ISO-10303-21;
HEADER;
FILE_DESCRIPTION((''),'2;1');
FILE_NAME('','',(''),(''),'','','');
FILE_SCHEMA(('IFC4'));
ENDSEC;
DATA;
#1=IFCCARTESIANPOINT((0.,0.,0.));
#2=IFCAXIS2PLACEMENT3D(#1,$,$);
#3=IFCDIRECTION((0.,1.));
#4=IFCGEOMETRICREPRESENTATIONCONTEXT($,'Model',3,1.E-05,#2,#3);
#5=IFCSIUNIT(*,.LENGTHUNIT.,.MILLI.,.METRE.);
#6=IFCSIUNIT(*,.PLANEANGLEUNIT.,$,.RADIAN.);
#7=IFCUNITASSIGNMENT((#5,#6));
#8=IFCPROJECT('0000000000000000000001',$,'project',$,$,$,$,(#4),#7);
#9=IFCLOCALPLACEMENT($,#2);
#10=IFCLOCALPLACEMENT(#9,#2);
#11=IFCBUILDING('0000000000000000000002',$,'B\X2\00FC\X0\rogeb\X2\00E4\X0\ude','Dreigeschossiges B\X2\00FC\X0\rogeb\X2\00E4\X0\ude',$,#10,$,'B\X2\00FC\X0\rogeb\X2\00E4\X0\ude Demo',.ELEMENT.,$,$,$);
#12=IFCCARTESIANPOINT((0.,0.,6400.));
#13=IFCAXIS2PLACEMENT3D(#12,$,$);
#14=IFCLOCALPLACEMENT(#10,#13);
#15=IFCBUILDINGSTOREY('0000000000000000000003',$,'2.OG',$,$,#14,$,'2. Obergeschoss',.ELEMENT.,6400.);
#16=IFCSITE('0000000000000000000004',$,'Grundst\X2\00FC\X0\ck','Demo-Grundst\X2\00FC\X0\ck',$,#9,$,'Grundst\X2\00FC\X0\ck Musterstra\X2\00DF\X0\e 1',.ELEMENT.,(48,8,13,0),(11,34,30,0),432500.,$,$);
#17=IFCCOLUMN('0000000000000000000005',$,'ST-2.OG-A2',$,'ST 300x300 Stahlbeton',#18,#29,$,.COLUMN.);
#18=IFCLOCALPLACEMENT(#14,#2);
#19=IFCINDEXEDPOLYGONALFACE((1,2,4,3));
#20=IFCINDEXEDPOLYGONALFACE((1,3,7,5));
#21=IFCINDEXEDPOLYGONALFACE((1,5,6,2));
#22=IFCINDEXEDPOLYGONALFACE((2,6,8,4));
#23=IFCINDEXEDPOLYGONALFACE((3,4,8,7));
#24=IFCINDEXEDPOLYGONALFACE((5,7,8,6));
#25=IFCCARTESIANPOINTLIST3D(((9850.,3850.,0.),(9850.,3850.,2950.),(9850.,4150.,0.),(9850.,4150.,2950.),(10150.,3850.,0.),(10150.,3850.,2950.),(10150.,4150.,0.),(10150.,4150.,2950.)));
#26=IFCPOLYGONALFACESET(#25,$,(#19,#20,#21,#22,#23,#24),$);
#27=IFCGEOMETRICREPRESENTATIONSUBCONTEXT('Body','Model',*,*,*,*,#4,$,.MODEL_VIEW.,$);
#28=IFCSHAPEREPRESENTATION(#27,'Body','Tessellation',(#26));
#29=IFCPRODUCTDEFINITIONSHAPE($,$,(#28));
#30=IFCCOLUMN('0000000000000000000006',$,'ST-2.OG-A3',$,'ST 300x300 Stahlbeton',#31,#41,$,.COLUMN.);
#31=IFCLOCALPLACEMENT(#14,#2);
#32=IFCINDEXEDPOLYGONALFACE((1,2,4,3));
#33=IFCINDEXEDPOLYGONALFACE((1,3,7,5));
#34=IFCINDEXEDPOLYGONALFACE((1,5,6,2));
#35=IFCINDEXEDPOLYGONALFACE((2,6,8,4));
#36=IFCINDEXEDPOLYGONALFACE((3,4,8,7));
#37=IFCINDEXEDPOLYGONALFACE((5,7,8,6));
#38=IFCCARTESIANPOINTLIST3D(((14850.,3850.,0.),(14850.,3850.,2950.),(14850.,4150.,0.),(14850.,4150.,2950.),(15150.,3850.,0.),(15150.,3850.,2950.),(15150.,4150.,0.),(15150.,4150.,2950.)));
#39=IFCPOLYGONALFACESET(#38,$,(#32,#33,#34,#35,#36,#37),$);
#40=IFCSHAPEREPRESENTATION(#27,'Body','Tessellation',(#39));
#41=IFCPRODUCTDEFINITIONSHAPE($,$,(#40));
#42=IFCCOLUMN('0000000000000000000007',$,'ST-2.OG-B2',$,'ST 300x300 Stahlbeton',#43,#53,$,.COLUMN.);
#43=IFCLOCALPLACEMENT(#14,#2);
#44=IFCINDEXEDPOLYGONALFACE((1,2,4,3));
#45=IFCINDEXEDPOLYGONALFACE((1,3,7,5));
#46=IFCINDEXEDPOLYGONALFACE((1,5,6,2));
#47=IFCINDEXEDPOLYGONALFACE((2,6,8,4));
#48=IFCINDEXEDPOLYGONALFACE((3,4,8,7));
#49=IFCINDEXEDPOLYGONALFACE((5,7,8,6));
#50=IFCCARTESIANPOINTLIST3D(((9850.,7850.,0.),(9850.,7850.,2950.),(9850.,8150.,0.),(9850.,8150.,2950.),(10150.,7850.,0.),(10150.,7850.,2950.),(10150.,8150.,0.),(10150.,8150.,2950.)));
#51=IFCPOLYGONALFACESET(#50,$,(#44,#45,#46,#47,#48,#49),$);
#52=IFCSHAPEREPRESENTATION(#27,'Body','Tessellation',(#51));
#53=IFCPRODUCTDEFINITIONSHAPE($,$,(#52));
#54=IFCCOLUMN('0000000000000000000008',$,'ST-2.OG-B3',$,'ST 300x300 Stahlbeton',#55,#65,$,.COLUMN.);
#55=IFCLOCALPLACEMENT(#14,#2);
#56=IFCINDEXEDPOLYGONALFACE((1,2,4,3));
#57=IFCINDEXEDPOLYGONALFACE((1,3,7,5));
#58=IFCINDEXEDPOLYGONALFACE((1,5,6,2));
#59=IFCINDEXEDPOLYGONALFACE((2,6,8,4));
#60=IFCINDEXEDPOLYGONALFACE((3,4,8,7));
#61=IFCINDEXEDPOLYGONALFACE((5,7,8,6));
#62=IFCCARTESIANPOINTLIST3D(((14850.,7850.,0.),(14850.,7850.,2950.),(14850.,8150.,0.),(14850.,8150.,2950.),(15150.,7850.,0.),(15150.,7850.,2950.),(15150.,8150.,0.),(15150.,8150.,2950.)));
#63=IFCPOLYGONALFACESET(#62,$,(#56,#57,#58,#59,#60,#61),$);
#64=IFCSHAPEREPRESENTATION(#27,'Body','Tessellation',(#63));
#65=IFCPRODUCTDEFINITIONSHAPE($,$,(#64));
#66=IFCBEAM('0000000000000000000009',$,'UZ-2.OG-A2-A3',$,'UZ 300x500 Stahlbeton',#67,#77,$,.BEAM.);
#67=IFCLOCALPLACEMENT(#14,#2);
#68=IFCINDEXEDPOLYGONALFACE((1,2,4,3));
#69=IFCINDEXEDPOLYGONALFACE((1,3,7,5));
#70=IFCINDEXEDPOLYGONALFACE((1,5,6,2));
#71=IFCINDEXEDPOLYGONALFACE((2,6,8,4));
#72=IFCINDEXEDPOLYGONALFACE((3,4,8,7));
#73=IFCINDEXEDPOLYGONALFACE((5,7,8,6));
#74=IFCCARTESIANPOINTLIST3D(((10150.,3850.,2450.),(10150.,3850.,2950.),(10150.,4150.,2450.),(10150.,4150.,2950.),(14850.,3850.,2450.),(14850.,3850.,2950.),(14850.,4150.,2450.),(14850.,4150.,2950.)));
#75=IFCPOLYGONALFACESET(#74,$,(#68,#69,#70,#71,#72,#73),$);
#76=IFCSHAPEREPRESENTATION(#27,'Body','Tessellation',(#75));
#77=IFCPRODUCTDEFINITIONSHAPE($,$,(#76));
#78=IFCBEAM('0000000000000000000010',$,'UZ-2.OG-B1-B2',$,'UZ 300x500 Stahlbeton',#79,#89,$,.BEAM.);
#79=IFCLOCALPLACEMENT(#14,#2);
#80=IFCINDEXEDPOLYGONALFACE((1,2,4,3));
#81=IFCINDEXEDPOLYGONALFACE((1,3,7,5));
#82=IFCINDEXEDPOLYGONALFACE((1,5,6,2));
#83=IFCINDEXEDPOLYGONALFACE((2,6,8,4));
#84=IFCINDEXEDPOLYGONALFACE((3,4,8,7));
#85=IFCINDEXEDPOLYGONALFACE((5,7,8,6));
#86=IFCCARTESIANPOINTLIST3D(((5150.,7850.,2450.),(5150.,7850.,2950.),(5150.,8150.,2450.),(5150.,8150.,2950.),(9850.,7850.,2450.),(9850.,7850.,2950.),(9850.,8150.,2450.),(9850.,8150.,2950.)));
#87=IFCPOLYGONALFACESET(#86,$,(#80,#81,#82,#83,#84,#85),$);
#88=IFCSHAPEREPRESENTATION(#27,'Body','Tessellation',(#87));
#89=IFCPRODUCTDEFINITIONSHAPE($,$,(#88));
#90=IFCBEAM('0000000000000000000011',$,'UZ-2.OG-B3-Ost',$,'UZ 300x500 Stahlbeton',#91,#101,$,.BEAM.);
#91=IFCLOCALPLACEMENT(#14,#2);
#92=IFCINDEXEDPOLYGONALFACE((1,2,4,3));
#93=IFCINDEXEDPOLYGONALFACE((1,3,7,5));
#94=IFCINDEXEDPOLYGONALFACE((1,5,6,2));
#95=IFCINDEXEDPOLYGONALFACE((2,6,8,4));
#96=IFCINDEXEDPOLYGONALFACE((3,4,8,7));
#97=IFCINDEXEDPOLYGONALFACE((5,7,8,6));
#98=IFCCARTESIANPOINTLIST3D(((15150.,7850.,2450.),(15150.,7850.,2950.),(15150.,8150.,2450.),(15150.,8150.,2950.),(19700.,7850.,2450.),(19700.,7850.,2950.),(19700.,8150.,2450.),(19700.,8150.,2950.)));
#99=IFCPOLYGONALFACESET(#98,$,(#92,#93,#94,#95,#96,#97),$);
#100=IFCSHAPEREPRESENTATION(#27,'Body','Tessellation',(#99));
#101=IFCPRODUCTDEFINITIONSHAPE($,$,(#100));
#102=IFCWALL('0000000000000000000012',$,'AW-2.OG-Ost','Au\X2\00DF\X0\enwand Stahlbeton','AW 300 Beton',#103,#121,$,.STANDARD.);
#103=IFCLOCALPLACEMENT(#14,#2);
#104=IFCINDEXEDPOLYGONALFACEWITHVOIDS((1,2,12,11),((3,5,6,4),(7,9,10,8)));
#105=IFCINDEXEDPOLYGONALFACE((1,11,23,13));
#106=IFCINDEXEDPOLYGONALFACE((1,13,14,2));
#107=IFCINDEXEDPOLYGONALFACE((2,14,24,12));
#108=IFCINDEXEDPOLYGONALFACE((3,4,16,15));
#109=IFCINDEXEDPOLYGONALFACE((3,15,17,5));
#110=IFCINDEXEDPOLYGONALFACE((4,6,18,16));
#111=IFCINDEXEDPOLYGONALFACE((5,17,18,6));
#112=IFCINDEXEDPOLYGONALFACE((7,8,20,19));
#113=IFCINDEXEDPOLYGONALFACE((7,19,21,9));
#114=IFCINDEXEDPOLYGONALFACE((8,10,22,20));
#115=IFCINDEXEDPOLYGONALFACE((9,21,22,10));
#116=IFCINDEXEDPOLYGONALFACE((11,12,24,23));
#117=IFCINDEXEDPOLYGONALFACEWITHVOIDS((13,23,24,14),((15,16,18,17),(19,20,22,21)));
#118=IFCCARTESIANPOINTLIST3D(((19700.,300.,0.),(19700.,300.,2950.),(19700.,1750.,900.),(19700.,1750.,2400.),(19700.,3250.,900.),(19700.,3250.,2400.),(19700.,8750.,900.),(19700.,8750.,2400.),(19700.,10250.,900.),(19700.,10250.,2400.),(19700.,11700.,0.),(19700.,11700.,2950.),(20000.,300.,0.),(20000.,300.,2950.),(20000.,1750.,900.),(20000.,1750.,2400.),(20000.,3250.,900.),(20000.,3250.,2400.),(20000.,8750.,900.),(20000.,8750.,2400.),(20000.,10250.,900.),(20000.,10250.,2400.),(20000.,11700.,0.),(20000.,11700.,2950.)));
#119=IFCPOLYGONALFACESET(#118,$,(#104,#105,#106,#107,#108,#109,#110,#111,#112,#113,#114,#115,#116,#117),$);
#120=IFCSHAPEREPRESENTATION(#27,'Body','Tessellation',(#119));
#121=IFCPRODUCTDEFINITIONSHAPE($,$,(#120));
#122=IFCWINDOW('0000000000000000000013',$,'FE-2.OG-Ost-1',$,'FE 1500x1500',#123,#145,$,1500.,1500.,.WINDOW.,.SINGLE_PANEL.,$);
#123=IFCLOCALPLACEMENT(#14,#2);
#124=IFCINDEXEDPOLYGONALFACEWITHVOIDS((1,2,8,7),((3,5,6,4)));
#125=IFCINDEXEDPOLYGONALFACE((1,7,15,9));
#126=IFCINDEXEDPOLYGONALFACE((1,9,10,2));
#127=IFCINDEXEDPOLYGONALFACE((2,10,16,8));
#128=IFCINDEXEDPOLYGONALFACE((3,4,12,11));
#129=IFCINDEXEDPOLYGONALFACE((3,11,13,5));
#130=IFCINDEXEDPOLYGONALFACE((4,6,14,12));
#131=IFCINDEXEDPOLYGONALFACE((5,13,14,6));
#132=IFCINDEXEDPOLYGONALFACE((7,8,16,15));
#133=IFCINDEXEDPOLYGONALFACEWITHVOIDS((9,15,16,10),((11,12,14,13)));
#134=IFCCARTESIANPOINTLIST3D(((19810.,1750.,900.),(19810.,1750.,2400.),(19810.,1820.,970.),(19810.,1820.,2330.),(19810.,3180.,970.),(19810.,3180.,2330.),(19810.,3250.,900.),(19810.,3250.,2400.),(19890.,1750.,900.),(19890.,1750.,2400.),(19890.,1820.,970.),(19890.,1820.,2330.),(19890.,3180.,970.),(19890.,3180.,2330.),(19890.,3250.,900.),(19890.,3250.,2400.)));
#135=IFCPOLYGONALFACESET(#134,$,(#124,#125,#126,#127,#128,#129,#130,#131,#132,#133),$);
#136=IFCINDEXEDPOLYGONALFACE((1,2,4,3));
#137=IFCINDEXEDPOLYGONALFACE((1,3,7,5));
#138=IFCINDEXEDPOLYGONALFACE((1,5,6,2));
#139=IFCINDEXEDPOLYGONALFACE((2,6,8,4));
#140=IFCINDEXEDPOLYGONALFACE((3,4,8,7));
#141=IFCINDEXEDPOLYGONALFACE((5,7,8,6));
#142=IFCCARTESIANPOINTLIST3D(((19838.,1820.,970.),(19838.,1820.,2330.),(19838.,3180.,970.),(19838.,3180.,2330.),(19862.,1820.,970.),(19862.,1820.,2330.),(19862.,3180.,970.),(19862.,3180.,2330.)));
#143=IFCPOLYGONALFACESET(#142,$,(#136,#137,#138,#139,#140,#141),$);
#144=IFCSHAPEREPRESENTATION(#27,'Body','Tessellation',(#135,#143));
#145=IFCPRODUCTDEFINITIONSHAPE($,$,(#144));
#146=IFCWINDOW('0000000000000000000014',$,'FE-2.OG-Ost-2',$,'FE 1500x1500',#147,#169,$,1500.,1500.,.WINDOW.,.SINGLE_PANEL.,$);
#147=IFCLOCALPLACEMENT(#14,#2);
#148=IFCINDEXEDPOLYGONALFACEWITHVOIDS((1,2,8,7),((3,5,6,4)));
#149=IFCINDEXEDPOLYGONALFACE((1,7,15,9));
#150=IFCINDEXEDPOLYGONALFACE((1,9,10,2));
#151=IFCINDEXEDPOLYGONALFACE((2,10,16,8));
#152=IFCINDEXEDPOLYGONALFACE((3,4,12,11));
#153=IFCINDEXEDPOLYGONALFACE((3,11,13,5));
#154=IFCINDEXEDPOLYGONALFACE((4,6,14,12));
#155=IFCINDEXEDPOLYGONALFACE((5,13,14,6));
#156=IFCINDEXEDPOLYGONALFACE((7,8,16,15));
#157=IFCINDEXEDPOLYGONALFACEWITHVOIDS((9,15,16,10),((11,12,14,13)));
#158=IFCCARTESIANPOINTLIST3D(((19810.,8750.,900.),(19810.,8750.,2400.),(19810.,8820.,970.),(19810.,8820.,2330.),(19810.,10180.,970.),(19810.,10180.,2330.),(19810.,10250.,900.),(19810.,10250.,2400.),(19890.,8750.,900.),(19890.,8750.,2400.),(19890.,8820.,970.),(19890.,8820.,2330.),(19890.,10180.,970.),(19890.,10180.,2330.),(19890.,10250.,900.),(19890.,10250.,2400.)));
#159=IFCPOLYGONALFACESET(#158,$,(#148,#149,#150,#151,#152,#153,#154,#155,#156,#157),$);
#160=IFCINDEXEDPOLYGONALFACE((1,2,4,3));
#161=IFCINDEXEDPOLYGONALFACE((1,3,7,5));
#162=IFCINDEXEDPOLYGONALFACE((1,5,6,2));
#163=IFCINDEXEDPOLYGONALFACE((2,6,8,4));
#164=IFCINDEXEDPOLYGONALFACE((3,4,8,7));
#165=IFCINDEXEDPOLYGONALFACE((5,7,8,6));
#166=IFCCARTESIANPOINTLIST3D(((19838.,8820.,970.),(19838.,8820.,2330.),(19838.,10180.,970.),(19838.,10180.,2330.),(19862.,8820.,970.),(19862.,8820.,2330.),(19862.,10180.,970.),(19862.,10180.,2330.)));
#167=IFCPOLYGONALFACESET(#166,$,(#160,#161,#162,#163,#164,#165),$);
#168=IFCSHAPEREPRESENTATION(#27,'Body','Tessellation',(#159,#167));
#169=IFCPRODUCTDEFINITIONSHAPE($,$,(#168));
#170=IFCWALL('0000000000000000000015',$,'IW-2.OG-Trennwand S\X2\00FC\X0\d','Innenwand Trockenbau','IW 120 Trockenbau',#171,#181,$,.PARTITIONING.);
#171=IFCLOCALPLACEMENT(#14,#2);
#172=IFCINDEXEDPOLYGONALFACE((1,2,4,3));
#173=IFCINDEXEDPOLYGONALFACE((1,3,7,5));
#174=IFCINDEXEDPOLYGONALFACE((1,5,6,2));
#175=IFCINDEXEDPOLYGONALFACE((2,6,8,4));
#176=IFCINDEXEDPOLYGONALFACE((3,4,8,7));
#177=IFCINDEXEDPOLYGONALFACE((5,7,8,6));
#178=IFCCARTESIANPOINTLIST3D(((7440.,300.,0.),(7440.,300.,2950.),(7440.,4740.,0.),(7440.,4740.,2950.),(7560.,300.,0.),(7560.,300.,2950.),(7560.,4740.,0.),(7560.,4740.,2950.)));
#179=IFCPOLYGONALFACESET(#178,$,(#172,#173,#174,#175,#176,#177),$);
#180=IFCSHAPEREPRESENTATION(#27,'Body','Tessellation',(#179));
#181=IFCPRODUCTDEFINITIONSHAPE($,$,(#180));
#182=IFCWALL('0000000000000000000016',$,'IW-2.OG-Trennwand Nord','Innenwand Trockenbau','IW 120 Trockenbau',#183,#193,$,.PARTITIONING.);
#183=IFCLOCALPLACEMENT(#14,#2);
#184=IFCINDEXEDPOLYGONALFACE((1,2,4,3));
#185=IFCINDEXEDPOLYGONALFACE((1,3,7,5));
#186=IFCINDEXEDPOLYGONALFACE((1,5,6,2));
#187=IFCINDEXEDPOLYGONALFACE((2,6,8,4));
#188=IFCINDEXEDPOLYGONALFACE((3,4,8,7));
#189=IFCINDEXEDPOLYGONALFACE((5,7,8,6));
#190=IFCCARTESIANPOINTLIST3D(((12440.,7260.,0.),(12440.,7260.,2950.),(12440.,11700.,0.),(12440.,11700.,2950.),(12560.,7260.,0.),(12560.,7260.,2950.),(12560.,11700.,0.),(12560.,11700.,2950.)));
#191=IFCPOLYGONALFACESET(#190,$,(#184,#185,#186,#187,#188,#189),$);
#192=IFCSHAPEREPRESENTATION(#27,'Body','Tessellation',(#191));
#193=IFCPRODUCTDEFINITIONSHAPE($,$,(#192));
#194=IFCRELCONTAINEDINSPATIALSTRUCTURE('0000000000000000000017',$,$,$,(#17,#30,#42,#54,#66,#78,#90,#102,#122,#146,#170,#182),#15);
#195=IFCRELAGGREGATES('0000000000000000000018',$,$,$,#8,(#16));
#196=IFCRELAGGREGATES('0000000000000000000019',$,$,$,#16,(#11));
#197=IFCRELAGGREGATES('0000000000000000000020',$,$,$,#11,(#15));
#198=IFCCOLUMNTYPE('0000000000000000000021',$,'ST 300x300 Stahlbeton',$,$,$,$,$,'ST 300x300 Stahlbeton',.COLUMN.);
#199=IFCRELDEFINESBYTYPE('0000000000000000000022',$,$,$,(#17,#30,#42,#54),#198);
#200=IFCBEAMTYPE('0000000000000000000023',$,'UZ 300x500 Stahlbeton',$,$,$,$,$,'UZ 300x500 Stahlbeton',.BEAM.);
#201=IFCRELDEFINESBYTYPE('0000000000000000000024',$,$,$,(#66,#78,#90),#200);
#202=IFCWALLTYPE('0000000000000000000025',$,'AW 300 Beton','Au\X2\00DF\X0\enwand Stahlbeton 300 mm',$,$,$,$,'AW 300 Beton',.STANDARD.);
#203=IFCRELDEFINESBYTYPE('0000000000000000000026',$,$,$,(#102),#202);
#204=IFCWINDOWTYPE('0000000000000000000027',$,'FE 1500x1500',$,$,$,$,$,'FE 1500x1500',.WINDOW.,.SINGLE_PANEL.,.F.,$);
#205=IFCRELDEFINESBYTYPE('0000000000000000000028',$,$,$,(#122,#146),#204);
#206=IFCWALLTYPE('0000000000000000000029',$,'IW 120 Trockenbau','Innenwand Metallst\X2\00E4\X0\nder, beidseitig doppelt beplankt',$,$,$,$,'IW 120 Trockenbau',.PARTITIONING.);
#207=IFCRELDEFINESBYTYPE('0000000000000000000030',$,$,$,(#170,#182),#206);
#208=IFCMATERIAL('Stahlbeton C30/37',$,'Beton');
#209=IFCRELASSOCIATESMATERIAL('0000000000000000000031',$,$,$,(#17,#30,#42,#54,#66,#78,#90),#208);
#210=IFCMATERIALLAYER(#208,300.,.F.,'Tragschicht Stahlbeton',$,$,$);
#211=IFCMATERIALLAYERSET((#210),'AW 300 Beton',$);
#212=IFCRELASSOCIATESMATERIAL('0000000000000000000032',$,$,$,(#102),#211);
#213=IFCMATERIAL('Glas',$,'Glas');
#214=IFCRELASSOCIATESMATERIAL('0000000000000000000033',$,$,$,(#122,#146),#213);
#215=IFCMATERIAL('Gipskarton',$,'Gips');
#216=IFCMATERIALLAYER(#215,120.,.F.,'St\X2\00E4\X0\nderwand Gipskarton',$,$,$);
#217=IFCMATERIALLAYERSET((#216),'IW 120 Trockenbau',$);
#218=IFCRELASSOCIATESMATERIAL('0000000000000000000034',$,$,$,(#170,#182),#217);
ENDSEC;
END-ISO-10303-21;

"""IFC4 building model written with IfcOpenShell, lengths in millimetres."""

from ifc_helpers import new_model, si_unit, direction, frame, frame_2d, origin, origin_2d, place, context, subcontext, project, spatial, polyline, rectangle, outline, extrude, material, layer, layer_set, layer_usage, type_object, element, fill, save


model = new_model("IFC4")

# Units and contexts
model_context = context("Model", 3, precision=1e-05, world=origin(), true_north=direction((0.0, 1.0)))
body_context = subcontext(model_context, "Body", "Model", "MODEL_VIEW")
ifc_project = project(units=[si_unit("LENGTHUNIT", "METRE", prefix="MILLI"), si_unit("PLANEANGLEUNIT", "RADIAN")], contexts=[model_context])

# Site, building, storey
site_placement = place(None, origin())
site = spatial("IfcSite", under=ifc_project, at=site_placement, Name="Grundstück", Description="Demo-Grundstück", LongName="Grundstück Musterstraße 1", CompositionType="ELEMENT", RefLatitude=(48, 8, 13, 0), RefLongitude=(11, 34, 30, 0), RefElevation=432500.0)
building_placement = place(site_placement, origin())
building = spatial("IfcBuilding", under=site, at=building_placement, Name="Bürogebäude", Description="Dreigeschossiges Bürogebäude", LongName="Bürogebäude Demo", CompositionType="ELEMENT")
storey_placement = place(building_placement, frame((0.0, 0.0, 6400.0)))
storey = spatial("IfcBuildingStorey", under=building, at=storey_placement, Name="2.OG", LongName="2. Obergeschoss", CompositionType="ELEMENT", Elevation=6400.0)

# Columns
ifc_material_1 = material(Name="Stahlbeton C30/37", Category="Beton")
column_type = type_object("IfcColumnType", Name="ST 300x300 Stahlbeton", ElementType="ST 300x300 Stahlbeton", PredefinedType="COLUMN")
for number, where, name in (
    (1, (10000.0, 4000.0, 0.0), "ST-2.OG-A2"),
    (2, (15000.0, 4000.0, 0.0), "ST-2.OG-A3"),
    (3, (10000.0, 8000.0, 0.0), "ST-2.OG-B2"),
    (4, (15000.0, 8000.0, 0.0), "ST-2.OG-B3"),
):
    element("IfcColumn", number, at=place(storey_placement, frame(where)), inside=storey, type_object=column_type, material=ifc_material_1, Name=name, ObjectType="ST 300x300 Stahlbeton", PredefinedType="COLUMN", context=body_context, shape_type="SweptSolid", body=[
        extrude(rectangle(XDim=300.0, YDim=300.0, at=origin_2d()), origin(), (0.0, 0.0, 1.0), 2950.0),
    ])

# Beams
beam_type = type_object("IfcBeamType", Name="UZ 300x500 Stahlbeton", ElementType="UZ 300x500 Stahlbeton", PredefinedType="BEAM")
for number, where, name in (
    (5, (10150.0, 4000.0, 2700.0), "UZ-2.OG-A2-A3"),
    (6, (5150.0, 8000.0, 2700.0), "UZ-2.OG-B1-B2"),
):
    element("IfcBeam", number, at=place(storey_placement, frame(where)), inside=storey, type_object=beam_type, material=ifc_material_1, Name=name, ObjectType="UZ 300x500 Stahlbeton", PredefinedType="BEAM", context=body_context, shape_type="SweptSolid", body=[
        extrude(rectangle(XDim=300.0, YDim=500.0, at=origin_2d()), frame((0.0, 0.0, 0.0), z_axis=(1.0, 0.0, 0.0), x_axis=(0.0, 1.0, 0.0)), (0.0, 0.0, 1.0), 4700.0),
    ])
beam_placement = place(storey_placement, frame((15150.0, 8000.0, 2700.0)))
element("IfcBeam", 7, at=beam_placement, inside=storey, type_object=beam_type, material=ifc_material_1, Name="UZ-2.OG-B3-Ost", ObjectType="UZ 300x500 Stahlbeton", PredefinedType="BEAM", context=body_context, shape_type="SweptSolid", body=[
    extrude(rectangle(XDim=300.0, YDim=500.0, at=origin_2d()), frame((0.0, 0.0, 0.0), z_axis=(1.0, 0.0, 0.0), x_axis=(0.0, 1.0, 0.0)), (0.0, 0.0, 1.0), 4550.0),
])

# Wall, openings, windows
ifc_layer_1 = layer(ifc_material_1, 300.0, ventilated=False, Name="Tragschicht Stahlbeton")
ifc_layer_set_1 = layer_set([ifc_layer_1], Name="AW 300 Beton")
ifc_layer_usage_1 = layer_usage(ifc_layer_set_1, "AXIS2", "POSITIVE", -150.0)
wall_type_1 = type_object("IfcWallType", Name="AW 300 Beton", Description="Außenwand Stahlbeton 300 mm", ElementType="AW 300 Beton", PredefinedType="STANDARD")
wall_placement = place(storey_placement, frame((19850.0, 300.0, 0.0), z_axis=(0.0, 0.0, 1.0), x_axis=(0.0, 1.0, 0.0)))
wall = element("IfcWall", 8, at=wall_placement, inside=storey, type_object=wall_type_1, material=ifc_layer_usage_1, Name="AW-2.OG-Ost", Description="Außenwand Stahlbeton", ObjectType="AW 300 Beton", PredefinedType="STANDARD", context=body_context, shape_type="SweptSolid", body=[
    extrude(rectangle(XDim=11400.0, YDim=300.0, at=frame_2d((5700.0, 0.0))), origin(), (0.0, 0.0, 1.0), 2950.0),
])
opening_1_placement = place(wall_placement, frame((2200.0, 0.0, 900.0)))
opening_1 = element("IfcOpeningElement", 9, at=opening_1_placement, cuts=wall, PredefinedType="OPENING", context=body_context, shape_type="SweptSolid", body=[
    extrude(rectangle(XDim=1500.0, YDim=340.0, at=origin_2d()), origin(), (0.0, 0.0, 1.0), 1500.0),
])
opening_2_placement = place(wall_placement, frame((9200.0, 0.0, 900.0)))
opening_2 = element("IfcOpeningElement", 10, at=opening_2_placement, cuts=wall, PredefinedType="OPENING", context=body_context, shape_type="SweptSolid", body=[
    extrude(rectangle(XDim=1500.0, YDim=340.0, at=origin_2d()), origin(), (0.0, 0.0, 1.0), 1500.0),
])
ifc_material_2 = material(Name="Glas", Category="Glas")
window_type = type_object("IfcWindowType", Name="FE 1500x1500", ElementType="FE 1500x1500", ParameterTakesPrecedence=False, PartitioningType="SINGLE_PANEL", PredefinedType="WINDOW")
window_1_placement = place(opening_1_placement, origin())
window_1 = element("IfcWindow", 11, at=window_1_placement, inside=storey, type_object=window_type, material=ifc_material_2, Name="FE-2.OG-Ost-1", ObjectType="FE 1500x1500", OverallHeight=1500.0, OverallWidth=1500.0, PartitioningType="SINGLE_PANEL", PredefinedType="WINDOW", context=body_context, shape_type="SweptSolid", body=[
    extrude(outline(polyline([(-750.0, 0.0), (750.0, 0.0), (750.0, 1500.0), (-750.0, 1500.0), (-750.0, 0.0)]), holes=[polyline([(-680.0, 70.0), (680.0, 70.0), (680.0, 1430.0), (-680.0, 1430.0), (-680.0, 70.0)])]), frame((0.0, 40.0, 0.0), z_axis=(0.0, -1.0, 0.0), x_axis=(1.0, 0.0, 0.0)), (0.0, 0.0, 1.0), 80.0),
    extrude(rectangle(XDim=1360.0, YDim=24.0, at=origin_2d()), frame((0.0, 0.0, 70.0)), (0.0, 0.0, 1.0), 1360.0),
])
fill(opening_1, window_1)
window_2_placement = place(opening_2_placement, origin())
window_2 = element("IfcWindow", 12, at=window_2_placement, inside=storey, type_object=window_type, material=ifc_material_2, Name="FE-2.OG-Ost-2", ObjectType="FE 1500x1500", OverallHeight=1500.0, OverallWidth=1500.0, PartitioningType="SINGLE_PANEL", PredefinedType="WINDOW", context=body_context, shape_type="SweptSolid", body=[
    extrude(outline(polyline([(-750.0, 0.0), (750.0, 0.0), (750.0, 1500.0), (-750.0, 1500.0), (-750.0, 0.0)]), holes=[polyline([(-680.0, 70.0), (680.0, 70.0), (680.0, 1430.0), (-680.0, 1430.0), (-680.0, 70.0)])]), frame((0.0, 40.0, 0.0), z_axis=(0.0, -1.0, 0.0), x_axis=(1.0, 0.0, 0.0)), (0.0, 0.0, 1.0), 80.0),
    extrude(rectangle(XDim=1360.0, YDim=24.0, at=origin_2d()), frame((0.0, 0.0, 70.0)), (0.0, 0.0, 1.0), 1360.0),
])
fill(opening_2, window_2)

# Walls
ifc_material_3 = material(Name="Gipskarton", Category="Gips")
ifc_layer_2 = layer(ifc_material_3, 120.0, ventilated=False, Name="Ständerwand Gipskarton")
ifc_layer_set_2 = layer_set([ifc_layer_2], Name="IW 120 Trockenbau")
ifc_layer_usage_2 = layer_usage(ifc_layer_set_2, "AXIS2", "POSITIVE", -60.0)
wall_type_2 = type_object("IfcWallType", Name="IW 120 Trockenbau", Description="Innenwand Metallständer, beidseitig doppelt beplankt", ElementType="IW 120 Trockenbau", PredefinedType="PARTITIONING")
for number, where, z_axis, x_axis, name in (
    (13, (7500.0, 300.0, 0.0), (0.0, 0.0, 1.0), (0.0, 1.0, 0.0), "IW-2.OG-Trennwand Süd"),
    (14, (12500.0, 7260.0, 0.0), (0.0, 0.0, 1.0), (0.0, 1.0, 0.0), "IW-2.OG-Trennwand Nord"),
):
    element("IfcWall", number, at=place(storey_placement, frame(where, z_axis=z_axis, x_axis=x_axis)), inside=storey, type_object=wall_type_2, material=ifc_layer_usage_2, Name=name, Description="Innenwand Trockenbau", ObjectType="IW 120 Trockenbau", PredefinedType="PARTITIONING", context=body_context, shape_type="SweptSolid", body=[
        extrude(rectangle(XDim=4440.0, YDim=120.0, at=frame_2d((2220.0, 0.0))), origin(), (0.0, 0.0, 1.0), 2950.0),
    ])

save(model, "model.ifc")
